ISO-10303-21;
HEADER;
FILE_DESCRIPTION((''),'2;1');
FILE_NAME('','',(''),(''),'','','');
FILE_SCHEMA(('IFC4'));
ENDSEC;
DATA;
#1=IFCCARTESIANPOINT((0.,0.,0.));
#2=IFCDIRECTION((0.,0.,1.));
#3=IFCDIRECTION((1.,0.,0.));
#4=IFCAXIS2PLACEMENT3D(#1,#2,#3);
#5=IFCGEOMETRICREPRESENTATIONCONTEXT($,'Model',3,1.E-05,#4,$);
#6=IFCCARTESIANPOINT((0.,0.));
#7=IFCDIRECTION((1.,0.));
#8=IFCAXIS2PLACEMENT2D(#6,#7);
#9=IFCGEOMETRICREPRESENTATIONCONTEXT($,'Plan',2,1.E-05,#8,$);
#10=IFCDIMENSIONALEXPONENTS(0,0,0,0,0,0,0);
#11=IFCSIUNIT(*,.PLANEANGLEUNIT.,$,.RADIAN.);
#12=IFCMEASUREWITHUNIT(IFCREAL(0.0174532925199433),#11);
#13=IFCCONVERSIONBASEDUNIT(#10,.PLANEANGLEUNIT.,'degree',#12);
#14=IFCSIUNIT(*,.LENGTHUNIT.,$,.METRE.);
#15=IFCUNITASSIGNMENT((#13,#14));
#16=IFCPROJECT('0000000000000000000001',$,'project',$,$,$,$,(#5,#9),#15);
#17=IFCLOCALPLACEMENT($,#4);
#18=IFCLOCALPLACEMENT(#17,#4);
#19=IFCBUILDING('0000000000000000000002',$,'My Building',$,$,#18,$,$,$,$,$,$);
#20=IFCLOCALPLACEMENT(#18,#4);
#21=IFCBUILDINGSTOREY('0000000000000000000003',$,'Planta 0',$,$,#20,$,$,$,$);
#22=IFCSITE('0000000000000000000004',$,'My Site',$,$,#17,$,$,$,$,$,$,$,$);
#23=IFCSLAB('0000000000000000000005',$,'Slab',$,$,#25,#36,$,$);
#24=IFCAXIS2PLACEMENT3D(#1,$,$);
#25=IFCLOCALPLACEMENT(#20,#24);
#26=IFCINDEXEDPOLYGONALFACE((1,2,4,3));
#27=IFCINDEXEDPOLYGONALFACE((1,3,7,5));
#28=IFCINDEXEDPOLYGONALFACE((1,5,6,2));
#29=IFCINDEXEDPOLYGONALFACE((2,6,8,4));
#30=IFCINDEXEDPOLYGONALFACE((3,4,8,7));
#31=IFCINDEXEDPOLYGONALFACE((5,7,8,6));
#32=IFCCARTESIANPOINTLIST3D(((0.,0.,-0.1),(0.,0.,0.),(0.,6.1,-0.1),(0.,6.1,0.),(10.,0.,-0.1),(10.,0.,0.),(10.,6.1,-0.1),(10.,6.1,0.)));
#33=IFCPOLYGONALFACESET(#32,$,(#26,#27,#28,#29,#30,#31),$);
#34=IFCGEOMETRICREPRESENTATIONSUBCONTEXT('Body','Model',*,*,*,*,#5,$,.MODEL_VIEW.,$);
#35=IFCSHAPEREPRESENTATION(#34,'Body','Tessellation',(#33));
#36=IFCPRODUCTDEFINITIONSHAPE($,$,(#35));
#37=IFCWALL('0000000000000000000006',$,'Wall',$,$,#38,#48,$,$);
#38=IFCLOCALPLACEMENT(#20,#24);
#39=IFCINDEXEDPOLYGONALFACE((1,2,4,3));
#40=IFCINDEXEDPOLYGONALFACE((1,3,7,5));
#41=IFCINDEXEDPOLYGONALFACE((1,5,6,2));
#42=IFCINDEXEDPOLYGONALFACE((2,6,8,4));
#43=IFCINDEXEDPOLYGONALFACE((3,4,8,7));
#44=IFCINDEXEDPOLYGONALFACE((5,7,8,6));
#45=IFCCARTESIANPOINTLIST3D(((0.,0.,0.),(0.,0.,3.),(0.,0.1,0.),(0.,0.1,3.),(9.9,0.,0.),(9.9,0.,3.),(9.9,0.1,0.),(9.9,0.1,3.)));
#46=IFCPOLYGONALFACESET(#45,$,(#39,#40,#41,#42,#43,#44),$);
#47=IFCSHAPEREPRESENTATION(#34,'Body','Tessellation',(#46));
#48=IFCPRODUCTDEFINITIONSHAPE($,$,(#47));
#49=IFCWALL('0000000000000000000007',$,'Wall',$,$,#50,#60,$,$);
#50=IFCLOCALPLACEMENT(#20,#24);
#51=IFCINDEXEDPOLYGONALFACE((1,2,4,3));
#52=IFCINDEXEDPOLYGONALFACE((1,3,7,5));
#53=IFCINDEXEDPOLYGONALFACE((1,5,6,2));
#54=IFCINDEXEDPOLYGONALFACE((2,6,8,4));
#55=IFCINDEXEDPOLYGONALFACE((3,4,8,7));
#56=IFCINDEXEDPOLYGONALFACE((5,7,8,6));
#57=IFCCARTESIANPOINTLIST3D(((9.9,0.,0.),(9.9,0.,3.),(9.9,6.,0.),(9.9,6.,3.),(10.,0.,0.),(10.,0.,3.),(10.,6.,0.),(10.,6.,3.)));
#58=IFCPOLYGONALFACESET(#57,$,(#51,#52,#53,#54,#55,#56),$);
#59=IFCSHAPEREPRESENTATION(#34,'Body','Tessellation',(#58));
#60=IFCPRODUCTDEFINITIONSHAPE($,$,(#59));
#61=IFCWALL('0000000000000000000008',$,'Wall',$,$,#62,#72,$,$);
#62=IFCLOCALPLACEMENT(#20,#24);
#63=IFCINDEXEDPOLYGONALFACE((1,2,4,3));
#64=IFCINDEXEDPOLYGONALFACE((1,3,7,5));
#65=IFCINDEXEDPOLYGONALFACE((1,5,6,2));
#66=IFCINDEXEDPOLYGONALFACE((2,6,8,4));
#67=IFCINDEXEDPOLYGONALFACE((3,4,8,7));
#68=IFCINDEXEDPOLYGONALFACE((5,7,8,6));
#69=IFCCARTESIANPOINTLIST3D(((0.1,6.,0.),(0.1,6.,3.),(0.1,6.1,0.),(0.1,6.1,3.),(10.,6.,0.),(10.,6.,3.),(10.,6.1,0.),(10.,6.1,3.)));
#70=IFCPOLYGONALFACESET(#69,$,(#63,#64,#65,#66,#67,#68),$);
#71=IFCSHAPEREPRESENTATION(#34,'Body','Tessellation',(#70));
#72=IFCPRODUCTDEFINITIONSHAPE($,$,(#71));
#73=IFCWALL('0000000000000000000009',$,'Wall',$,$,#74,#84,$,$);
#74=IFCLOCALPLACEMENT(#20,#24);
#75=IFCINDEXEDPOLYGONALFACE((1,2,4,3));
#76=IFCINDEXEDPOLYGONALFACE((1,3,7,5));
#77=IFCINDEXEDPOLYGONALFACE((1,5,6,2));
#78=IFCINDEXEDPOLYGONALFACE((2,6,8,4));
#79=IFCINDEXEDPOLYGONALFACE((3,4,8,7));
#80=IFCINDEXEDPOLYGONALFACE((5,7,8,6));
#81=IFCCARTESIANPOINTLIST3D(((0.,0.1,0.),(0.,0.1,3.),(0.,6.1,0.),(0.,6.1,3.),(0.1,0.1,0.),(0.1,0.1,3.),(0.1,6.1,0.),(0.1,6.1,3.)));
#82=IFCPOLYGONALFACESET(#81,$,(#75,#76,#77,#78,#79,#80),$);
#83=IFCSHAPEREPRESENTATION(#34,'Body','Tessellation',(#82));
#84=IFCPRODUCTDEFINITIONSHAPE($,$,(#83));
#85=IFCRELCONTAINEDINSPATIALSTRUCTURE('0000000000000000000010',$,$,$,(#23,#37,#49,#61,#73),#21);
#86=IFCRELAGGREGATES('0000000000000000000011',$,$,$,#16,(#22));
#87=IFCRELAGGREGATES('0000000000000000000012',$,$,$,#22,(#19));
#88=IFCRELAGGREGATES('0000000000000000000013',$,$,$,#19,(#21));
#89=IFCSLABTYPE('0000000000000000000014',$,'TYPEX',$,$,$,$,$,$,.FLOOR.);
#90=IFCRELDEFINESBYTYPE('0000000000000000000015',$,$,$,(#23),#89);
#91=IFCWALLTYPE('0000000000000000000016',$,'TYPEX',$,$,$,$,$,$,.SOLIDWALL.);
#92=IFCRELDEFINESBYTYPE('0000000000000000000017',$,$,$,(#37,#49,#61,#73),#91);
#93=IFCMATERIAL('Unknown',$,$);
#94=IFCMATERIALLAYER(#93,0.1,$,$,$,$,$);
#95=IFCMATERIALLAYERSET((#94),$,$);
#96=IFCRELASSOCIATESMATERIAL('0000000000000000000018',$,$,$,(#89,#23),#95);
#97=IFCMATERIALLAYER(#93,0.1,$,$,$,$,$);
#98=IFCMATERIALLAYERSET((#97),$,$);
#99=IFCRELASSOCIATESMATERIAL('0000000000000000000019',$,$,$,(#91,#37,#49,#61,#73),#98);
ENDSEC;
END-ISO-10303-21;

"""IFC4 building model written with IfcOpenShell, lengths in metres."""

from ifc_helpers import new_model, entity, si_unit, converted_unit, frame, origin_with_axes, origin_2d_with_axis, place, context, subcontext, project, spatial, line, indexed_curve, outline, extrude, material, layer, layer_set, layer_usage, type_object, element, save


model = new_model("IFC4")

# Units and contexts
model_context = context("Model", 3, precision=1e-05, world=origin_with_axes())
plan_context = context("Plan", 2, precision=1e-05, world=origin_2d_with_axis())
body_context = subcontext(model_context, "Body", "Model", "MODEL_VIEW")
ifc_project = project(units=[converted_unit("PLANEANGLEUNIT", "degree", entity("IfcReal", 0.0174532925199433), si_unit("PLANEANGLEUNIT", "RADIAN"), dimensions=[0, 0, 0, 0, 0, 0, 0]), si_unit("LENGTHUNIT", "METRE")], contexts=[model_context, plan_context])

# Site, building, storey
site_placement = place(None, origin_with_axes())
site = spatial("IfcSite", under=ifc_project, at=site_placement, Name="My Site")
building_placement = place(site_placement, origin_with_axes())
building = spatial("IfcBuilding", under=site, at=building_placement, Name="My Building")
storey_placement = place(building_placement, origin_with_axes())
storey = spatial("IfcBuildingStorey", under=building, at=storey_placement, Name="Planta 0")

# Slab
ifc_material = material(Name="Unknown")
ifc_layer_1 = layer(ifc_material, 0.1)
ifc_layer_set_1 = layer_set([ifc_layer_1])
ifc_layer_usage_1 = layer_usage(ifc_layer_set_1, "AXIS3", "POSITIVE", 0.0)
slab_type = type_object("IfcSlabType", Name="TYPEX", PredefinedType="FLOOR", material=ifc_layer_set_1)
slab_placement = place(storey_placement, frame((0.0, 0.0, -0.1), z_axis=(0.0, 0.0, 1.0), x_axis=(1.0, 0.0, 0.0)))
element("IfcSlab", 1, at=slab_placement, inside=storey, type_object=slab_type, material=ifc_layer_usage_1, Name="Slab", context=body_context, shape_type="SweptSolid", body=[
    extrude(outline(indexed_curve([(0.0, 0.0), (10.0, 0.0), (10.0, 6.1), (0.0, 6.1)], segments=[line(3, 2), line(2, 1), line(1, 4), line(4, 3)], self_intersect=False)), None, (0.0, 0.0, 1.0), 0.1),
])

# Walls
ifc_layer_2 = layer(ifc_material, 0.1)
ifc_layer_set_2 = layer_set([ifc_layer_2])
ifc_layer_usage_2 = layer_usage(ifc_layer_set_2, "AXIS2", "POSITIVE", 0.0)
wall_type = type_object("IfcWallType", Name="TYPEX", PredefinedType="SOLIDWALL", material=ifc_layer_set_2)
wall_1_placement = place(storey_placement, origin_with_axes())
element("IfcWall", 2, at=wall_1_placement, inside=storey, type_object=wall_type, material=ifc_layer_usage_2, Name="Wall", context=body_context, shape_type="SweptSolid", body=[
    extrude(outline(indexed_curve([(0.0, 0.0), (0.0, 0.1), (9.9, 0.1), (9.9, 0.0), (0.0, 0.0)], self_intersect=False)), origin_with_axes(), (0.0, 0.0, 1.0), 3.0),
])
ifc_layer_usage_3 = layer_usage(ifc_layer_set_2, "AXIS2", "POSITIVE", 0.0)
wall_2_placement = place(storey_placement, frame((10.0, 0.0, 0.0), z_axis=(0.0, 0.0, 1.0), x_axis=(0.0, 1.0, 0.0)))
element("IfcWall", 3, at=wall_2_placement, inside=storey, type_object=wall_type, material=ifc_layer_usage_3, Name="Wall", context=body_context, shape_type="SweptSolid", body=[
    extrude(outline(indexed_curve([(0.0, 0.0), (0.0, 0.1), (6.0, 0.1), (6.0, 0.0), (0.0, 0.0)], self_intersect=False)), origin_with_axes(), (0.0, 0.0, 1.0), 3.0),
])
ifc_layer_usage_4 = layer_usage(ifc_layer_set_2, "AXIS2", "POSITIVE", 0.0)
wall_3_placement = place(storey_placement, frame((10.0, 6.1, 0.0), z_axis=(0.0, 0.0, 1.0), x_axis=(-1.0, 0.0, 0.0)))
element("IfcWall", 4, at=wall_3_placement, inside=storey, type_object=wall_type, material=ifc_layer_usage_4, Name="Wall", context=body_context, shape_type="SweptSolid", body=[
    extrude(outline(indexed_curve([(0.0, 0.0), (0.0, 0.1), (9.9, 0.1), (9.9, 0.0), (0.0, 0.0)], self_intersect=False)), origin_with_axes(), (0.0, 0.0, 1.0), 3.0),
])
ifc_layer_usage_5 = layer_usage(ifc_layer_set_2, "AXIS2", "POSITIVE", 0.0)
wall_4_placement = place(storey_placement, frame((0.0, 6.1, 0.0), z_axis=(0.0, 0.0, 1.0), x_axis=(0.0, -1.0, 0.0)))
element("IfcWall", 5, at=wall_4_placement, inside=storey, type_object=wall_type, material=ifc_layer_usage_5, Name="Wall", context=body_context, shape_type="SweptSolid", body=[
    extrude(outline(indexed_curve([(0.0, 0.0), (0.0, 0.1), (6.0, 0.1), (6.0, 0.0), (0.0, 0.0)], self_intersect=False)), origin_with_axes(), (0.0, 0.0, 1.0), 3.0),
])

save(model, "model.ifc")
